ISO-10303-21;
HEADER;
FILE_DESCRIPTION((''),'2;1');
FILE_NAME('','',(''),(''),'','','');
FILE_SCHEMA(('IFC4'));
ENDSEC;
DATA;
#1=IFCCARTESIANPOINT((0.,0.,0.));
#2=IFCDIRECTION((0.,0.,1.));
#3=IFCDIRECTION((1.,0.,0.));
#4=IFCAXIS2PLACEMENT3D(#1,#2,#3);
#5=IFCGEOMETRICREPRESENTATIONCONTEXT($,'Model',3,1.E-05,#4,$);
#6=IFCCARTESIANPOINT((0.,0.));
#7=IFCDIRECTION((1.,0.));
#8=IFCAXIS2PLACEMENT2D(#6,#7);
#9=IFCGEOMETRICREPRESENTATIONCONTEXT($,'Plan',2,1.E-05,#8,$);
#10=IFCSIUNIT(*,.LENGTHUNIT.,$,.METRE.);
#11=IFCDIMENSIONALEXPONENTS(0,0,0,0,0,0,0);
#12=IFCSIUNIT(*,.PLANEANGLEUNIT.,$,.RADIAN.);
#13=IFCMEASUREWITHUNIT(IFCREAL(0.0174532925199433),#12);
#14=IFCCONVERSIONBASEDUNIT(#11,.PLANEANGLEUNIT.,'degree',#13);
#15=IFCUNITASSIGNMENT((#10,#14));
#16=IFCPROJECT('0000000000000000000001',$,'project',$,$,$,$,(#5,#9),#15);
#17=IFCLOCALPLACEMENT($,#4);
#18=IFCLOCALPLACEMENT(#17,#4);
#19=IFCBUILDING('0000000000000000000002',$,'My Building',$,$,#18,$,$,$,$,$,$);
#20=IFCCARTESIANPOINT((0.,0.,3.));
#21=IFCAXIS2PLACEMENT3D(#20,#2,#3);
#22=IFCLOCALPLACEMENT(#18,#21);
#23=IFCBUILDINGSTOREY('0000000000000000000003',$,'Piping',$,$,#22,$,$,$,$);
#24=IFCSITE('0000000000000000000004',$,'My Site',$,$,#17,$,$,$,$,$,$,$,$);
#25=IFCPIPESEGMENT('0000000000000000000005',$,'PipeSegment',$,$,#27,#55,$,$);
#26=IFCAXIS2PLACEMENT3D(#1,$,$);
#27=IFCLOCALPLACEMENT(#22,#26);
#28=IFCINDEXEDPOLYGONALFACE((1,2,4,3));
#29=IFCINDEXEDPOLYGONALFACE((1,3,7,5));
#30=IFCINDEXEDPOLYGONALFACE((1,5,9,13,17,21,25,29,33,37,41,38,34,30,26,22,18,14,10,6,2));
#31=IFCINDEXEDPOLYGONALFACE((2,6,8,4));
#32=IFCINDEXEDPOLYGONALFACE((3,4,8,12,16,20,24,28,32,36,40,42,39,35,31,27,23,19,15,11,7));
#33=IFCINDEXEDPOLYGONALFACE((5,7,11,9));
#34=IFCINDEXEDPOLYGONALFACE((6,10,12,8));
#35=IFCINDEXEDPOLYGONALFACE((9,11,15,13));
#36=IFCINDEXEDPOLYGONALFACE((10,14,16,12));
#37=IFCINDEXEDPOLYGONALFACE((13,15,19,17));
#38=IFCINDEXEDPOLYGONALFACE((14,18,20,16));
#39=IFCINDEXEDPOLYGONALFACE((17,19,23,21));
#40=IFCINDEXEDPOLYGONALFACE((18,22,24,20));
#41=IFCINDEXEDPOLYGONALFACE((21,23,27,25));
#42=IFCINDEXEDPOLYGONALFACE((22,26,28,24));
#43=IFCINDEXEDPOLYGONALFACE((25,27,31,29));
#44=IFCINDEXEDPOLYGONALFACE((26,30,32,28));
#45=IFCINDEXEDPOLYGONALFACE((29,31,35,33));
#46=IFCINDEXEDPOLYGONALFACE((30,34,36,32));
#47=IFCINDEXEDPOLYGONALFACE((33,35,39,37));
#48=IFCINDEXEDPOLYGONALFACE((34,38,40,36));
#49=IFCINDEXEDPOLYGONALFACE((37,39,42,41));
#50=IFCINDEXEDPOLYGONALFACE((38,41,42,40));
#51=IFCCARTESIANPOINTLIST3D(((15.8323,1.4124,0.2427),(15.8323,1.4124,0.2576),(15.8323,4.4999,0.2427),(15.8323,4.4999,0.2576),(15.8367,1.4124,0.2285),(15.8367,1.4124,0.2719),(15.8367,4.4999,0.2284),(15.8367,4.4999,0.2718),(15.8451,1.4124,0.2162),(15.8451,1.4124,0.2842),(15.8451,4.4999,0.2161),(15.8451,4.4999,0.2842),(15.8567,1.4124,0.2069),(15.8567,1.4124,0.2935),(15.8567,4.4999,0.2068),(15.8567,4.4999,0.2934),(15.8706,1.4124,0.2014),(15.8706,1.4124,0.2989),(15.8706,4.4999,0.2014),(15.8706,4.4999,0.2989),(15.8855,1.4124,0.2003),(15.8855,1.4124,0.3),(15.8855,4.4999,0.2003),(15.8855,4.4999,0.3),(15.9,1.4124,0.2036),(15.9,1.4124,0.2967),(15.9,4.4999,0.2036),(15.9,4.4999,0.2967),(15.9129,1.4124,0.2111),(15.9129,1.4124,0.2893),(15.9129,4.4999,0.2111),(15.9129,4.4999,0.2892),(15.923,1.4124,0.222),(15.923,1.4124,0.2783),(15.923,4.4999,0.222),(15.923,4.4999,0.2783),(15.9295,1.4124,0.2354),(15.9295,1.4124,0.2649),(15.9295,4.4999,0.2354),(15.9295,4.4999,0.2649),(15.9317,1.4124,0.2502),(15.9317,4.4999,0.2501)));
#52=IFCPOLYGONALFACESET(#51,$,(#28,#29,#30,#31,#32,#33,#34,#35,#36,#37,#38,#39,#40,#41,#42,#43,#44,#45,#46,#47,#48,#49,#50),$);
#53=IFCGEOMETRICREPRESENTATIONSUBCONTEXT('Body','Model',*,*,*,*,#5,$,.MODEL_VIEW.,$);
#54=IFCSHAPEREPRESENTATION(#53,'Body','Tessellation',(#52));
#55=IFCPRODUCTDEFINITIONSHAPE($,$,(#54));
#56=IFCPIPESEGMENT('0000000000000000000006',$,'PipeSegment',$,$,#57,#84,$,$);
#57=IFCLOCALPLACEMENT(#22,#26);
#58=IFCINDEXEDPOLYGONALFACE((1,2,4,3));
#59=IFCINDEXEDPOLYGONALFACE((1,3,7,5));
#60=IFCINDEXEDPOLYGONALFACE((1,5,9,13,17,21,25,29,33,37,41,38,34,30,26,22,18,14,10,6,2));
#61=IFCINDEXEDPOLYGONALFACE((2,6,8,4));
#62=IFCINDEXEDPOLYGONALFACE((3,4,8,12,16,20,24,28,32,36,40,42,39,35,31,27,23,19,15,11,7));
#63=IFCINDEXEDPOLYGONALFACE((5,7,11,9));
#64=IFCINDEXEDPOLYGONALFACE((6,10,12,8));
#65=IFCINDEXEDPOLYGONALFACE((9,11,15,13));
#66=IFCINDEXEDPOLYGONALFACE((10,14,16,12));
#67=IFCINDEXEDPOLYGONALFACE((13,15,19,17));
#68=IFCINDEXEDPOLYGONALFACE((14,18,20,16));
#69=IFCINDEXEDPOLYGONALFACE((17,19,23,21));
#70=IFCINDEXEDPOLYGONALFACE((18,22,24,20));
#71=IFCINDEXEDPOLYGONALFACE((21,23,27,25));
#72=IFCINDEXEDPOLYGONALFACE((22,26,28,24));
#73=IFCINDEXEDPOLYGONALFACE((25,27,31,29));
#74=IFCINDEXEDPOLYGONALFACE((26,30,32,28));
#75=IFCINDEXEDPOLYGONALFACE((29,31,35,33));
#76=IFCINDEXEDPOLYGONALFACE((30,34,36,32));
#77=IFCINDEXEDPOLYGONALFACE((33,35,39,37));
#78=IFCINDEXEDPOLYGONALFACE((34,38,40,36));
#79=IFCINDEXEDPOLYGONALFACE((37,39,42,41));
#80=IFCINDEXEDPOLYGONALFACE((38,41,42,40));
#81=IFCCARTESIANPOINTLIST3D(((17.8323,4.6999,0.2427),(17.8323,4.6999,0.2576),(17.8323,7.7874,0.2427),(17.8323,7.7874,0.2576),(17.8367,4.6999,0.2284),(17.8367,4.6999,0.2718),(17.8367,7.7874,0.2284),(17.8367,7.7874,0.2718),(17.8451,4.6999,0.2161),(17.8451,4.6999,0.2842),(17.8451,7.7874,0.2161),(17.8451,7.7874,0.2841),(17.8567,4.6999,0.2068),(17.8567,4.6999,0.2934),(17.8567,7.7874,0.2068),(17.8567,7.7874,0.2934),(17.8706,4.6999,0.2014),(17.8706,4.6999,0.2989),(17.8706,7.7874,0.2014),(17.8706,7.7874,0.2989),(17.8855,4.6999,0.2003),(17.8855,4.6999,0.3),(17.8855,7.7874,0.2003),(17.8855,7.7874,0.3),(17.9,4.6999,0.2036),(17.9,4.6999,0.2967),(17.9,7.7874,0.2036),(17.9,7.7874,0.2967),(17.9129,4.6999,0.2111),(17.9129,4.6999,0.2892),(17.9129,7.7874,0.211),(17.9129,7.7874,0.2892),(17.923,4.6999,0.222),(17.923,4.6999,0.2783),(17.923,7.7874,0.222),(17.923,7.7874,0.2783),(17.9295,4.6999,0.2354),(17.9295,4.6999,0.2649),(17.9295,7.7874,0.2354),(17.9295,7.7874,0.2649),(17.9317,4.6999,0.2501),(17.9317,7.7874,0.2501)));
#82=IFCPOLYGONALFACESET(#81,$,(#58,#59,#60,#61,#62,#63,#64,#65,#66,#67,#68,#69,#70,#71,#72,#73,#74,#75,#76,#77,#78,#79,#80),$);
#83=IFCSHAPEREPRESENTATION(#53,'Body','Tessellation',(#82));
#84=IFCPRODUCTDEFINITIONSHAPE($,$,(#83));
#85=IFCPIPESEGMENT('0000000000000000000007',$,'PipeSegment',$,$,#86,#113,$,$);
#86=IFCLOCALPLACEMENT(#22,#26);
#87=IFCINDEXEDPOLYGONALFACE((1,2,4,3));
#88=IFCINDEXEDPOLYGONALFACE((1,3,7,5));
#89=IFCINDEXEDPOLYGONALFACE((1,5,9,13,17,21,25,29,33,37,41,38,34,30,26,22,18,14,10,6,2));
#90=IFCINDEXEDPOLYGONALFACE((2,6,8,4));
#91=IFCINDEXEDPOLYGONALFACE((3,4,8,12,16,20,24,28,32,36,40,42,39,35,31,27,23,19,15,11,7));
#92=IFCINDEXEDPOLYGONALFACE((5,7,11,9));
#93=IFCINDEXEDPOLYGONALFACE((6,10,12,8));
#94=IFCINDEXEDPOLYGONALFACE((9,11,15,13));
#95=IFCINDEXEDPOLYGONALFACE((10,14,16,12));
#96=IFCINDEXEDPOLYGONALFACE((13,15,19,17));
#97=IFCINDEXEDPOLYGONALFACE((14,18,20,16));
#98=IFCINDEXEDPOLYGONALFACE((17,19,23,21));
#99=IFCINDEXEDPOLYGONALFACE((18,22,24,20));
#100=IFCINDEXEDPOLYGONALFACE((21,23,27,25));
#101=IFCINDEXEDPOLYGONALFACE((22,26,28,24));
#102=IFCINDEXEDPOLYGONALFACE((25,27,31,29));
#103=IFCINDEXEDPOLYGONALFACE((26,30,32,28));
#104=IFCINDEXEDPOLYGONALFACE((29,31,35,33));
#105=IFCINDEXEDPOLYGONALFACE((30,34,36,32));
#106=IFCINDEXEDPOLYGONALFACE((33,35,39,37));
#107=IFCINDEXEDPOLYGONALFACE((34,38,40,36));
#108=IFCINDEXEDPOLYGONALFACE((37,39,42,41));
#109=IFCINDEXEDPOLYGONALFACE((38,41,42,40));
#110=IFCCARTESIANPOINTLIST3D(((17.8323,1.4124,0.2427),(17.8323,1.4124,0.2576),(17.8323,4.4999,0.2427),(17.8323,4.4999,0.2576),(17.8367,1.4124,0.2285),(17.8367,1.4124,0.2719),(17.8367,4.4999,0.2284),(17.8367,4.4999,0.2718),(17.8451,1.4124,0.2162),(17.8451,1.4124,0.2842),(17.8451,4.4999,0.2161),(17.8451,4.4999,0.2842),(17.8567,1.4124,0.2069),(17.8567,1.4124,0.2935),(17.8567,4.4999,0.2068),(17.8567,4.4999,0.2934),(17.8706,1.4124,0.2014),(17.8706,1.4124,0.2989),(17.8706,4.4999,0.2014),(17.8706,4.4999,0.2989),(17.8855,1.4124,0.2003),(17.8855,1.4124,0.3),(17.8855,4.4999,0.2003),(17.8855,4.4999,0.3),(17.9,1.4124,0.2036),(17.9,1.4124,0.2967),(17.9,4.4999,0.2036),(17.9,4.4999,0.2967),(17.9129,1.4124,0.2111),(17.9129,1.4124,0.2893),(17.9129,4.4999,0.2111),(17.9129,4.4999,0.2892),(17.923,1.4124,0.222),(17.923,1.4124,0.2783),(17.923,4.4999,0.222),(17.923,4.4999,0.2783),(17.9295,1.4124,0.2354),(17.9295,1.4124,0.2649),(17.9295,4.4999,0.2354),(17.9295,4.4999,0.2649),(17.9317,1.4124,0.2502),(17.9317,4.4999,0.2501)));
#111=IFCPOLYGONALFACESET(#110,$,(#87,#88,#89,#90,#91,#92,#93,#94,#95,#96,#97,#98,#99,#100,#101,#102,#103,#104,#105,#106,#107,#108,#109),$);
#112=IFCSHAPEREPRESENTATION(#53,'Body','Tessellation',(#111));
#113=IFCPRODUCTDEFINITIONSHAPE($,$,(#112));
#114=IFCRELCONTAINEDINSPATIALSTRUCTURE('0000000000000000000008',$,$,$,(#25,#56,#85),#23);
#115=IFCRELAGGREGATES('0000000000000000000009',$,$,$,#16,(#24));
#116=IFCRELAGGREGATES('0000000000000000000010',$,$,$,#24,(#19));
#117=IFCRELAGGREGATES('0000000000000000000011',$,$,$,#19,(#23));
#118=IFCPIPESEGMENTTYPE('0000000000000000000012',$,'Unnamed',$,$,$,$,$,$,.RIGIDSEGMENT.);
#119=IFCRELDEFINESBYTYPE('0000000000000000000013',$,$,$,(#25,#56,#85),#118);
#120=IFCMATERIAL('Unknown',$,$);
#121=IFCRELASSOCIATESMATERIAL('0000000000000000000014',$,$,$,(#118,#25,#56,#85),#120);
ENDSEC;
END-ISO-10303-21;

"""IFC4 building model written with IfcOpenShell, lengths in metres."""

from ifc_helpers import new_model, entity, si_unit, converted_unit, frame, origin_with_axes, origin_2d_with_axis, place, context, subcontext, project, spatial, circle, extrude, material, material_profile, profile_set, profile_usage, type_object, element, save


model = new_model("IFC4")

# Units and contexts
model_context = context("Model", 3, precision=1e-05, world=origin_with_axes())
plan_context = context("Plan", 2, precision=1e-05, world=origin_2d_with_axis())
body_context = subcontext(model_context, "Body", "Model", "MODEL_VIEW")
ifc_project = project(units=[si_unit("LENGTHUNIT", "METRE"), converted_unit("PLANEANGLEUNIT", "degree", entity("IfcReal", 0.0174532925199433), si_unit("PLANEANGLEUNIT", "RADIAN"), dimensions=[0, 0, 0, 0, 0, 0, 0])], contexts=[model_context, plan_context])

# Site, building, storey
site_placement = place(None, origin_with_axes())
site = spatial("IfcSite", under=ifc_project, at=site_placement, Name="My Site")
building_placement = place(site_placement, origin_with_axes())
building = spatial("IfcBuilding", under=site, at=building_placement, Name="My Building")
storey_placement = place(building_placement, frame((0.0, 0.0, 3.0), z_axis=(0.0, 0.0, 1.0), x_axis=(1.0, 0.0, 0.0)))
storey = spatial("IfcBuildingStorey", under=building, at=storey_placement, Name="Piping")

# Pipe segments
ifc_material = material(Name="Unknown")
ifc_material_profile_1 = material_profile(ifc_material, circle(Radius=0.05))
ifc_profile_set_1 = profile_set([ifc_material_profile_1])
pipe_segment_type = type_object("IfcPipeSegmentType", Name="Unnamed", PredefinedType="RIGIDSEGMENT", material=ifc_profile_set_1)
ifc_profile_usage_1 = profile_usage(ifc_profile_set_1, cardinal=5)
pipe_segment_1_placement = place(storey_placement, frame((15.8817, 4.4999, 0.2501), z_axis=(0.0, -1.0, 0.000008), x_axis=(1.0, 0.0, 0.0)))
element("IfcPipeSegment", 1, at=pipe_segment_1_placement, inside=storey, type_object=pipe_segment_type, material=ifc_profile_usage_1, Name="PipeSegment", context=body_context, shape_type="SweptSolid", body=[
    extrude(circle(Radius=0.05), origin_with_axes(), (0.0, 0.0, 1.0), 3.0875),
])
ifc_profile_usage_2 = profile_usage(ifc_profile_set_1, cardinal=5)
pipe_segment_2_placement = place(storey_placement, frame((17.8817, 4.6999, 0.2501), z_axis=(0.0, 1.0, -0.000008), x_axis=(1.0, 0.0, 0.0)))
element("IfcPipeSegment", 2, at=pipe_segment_2_placement, inside=storey, type_object=pipe_segment_type, material=ifc_profile_usage_2, Name="PipeSegment", context=body_context, shape_type="SweptSolid", body=[
    extrude(circle(Radius=0.05), origin_with_axes(), (0.0, 0.0, 1.0), 3.0875),
])
ifc_profile_usage_3 = profile_usage(ifc_profile_set_1, cardinal=5)
pipe_segment_3_placement = place(storey_placement, frame((17.8817, 4.4999, 0.2501), z_axis=(0.0, -1.0, 0.000008), x_axis=(1.0, 0.0, 0.0)))
element("IfcPipeSegment", 3, at=pipe_segment_3_placement, inside=storey, type_object=pipe_segment_type, material=ifc_profile_usage_3, Name="PipeSegment", context=body_context, shape_type="SweptSolid", body=[
    extrude(circle(Radius=0.05), origin_with_axes(), (0.0, 0.0, 1.0), 3.0875),
])

save(model, "model.ifc")
